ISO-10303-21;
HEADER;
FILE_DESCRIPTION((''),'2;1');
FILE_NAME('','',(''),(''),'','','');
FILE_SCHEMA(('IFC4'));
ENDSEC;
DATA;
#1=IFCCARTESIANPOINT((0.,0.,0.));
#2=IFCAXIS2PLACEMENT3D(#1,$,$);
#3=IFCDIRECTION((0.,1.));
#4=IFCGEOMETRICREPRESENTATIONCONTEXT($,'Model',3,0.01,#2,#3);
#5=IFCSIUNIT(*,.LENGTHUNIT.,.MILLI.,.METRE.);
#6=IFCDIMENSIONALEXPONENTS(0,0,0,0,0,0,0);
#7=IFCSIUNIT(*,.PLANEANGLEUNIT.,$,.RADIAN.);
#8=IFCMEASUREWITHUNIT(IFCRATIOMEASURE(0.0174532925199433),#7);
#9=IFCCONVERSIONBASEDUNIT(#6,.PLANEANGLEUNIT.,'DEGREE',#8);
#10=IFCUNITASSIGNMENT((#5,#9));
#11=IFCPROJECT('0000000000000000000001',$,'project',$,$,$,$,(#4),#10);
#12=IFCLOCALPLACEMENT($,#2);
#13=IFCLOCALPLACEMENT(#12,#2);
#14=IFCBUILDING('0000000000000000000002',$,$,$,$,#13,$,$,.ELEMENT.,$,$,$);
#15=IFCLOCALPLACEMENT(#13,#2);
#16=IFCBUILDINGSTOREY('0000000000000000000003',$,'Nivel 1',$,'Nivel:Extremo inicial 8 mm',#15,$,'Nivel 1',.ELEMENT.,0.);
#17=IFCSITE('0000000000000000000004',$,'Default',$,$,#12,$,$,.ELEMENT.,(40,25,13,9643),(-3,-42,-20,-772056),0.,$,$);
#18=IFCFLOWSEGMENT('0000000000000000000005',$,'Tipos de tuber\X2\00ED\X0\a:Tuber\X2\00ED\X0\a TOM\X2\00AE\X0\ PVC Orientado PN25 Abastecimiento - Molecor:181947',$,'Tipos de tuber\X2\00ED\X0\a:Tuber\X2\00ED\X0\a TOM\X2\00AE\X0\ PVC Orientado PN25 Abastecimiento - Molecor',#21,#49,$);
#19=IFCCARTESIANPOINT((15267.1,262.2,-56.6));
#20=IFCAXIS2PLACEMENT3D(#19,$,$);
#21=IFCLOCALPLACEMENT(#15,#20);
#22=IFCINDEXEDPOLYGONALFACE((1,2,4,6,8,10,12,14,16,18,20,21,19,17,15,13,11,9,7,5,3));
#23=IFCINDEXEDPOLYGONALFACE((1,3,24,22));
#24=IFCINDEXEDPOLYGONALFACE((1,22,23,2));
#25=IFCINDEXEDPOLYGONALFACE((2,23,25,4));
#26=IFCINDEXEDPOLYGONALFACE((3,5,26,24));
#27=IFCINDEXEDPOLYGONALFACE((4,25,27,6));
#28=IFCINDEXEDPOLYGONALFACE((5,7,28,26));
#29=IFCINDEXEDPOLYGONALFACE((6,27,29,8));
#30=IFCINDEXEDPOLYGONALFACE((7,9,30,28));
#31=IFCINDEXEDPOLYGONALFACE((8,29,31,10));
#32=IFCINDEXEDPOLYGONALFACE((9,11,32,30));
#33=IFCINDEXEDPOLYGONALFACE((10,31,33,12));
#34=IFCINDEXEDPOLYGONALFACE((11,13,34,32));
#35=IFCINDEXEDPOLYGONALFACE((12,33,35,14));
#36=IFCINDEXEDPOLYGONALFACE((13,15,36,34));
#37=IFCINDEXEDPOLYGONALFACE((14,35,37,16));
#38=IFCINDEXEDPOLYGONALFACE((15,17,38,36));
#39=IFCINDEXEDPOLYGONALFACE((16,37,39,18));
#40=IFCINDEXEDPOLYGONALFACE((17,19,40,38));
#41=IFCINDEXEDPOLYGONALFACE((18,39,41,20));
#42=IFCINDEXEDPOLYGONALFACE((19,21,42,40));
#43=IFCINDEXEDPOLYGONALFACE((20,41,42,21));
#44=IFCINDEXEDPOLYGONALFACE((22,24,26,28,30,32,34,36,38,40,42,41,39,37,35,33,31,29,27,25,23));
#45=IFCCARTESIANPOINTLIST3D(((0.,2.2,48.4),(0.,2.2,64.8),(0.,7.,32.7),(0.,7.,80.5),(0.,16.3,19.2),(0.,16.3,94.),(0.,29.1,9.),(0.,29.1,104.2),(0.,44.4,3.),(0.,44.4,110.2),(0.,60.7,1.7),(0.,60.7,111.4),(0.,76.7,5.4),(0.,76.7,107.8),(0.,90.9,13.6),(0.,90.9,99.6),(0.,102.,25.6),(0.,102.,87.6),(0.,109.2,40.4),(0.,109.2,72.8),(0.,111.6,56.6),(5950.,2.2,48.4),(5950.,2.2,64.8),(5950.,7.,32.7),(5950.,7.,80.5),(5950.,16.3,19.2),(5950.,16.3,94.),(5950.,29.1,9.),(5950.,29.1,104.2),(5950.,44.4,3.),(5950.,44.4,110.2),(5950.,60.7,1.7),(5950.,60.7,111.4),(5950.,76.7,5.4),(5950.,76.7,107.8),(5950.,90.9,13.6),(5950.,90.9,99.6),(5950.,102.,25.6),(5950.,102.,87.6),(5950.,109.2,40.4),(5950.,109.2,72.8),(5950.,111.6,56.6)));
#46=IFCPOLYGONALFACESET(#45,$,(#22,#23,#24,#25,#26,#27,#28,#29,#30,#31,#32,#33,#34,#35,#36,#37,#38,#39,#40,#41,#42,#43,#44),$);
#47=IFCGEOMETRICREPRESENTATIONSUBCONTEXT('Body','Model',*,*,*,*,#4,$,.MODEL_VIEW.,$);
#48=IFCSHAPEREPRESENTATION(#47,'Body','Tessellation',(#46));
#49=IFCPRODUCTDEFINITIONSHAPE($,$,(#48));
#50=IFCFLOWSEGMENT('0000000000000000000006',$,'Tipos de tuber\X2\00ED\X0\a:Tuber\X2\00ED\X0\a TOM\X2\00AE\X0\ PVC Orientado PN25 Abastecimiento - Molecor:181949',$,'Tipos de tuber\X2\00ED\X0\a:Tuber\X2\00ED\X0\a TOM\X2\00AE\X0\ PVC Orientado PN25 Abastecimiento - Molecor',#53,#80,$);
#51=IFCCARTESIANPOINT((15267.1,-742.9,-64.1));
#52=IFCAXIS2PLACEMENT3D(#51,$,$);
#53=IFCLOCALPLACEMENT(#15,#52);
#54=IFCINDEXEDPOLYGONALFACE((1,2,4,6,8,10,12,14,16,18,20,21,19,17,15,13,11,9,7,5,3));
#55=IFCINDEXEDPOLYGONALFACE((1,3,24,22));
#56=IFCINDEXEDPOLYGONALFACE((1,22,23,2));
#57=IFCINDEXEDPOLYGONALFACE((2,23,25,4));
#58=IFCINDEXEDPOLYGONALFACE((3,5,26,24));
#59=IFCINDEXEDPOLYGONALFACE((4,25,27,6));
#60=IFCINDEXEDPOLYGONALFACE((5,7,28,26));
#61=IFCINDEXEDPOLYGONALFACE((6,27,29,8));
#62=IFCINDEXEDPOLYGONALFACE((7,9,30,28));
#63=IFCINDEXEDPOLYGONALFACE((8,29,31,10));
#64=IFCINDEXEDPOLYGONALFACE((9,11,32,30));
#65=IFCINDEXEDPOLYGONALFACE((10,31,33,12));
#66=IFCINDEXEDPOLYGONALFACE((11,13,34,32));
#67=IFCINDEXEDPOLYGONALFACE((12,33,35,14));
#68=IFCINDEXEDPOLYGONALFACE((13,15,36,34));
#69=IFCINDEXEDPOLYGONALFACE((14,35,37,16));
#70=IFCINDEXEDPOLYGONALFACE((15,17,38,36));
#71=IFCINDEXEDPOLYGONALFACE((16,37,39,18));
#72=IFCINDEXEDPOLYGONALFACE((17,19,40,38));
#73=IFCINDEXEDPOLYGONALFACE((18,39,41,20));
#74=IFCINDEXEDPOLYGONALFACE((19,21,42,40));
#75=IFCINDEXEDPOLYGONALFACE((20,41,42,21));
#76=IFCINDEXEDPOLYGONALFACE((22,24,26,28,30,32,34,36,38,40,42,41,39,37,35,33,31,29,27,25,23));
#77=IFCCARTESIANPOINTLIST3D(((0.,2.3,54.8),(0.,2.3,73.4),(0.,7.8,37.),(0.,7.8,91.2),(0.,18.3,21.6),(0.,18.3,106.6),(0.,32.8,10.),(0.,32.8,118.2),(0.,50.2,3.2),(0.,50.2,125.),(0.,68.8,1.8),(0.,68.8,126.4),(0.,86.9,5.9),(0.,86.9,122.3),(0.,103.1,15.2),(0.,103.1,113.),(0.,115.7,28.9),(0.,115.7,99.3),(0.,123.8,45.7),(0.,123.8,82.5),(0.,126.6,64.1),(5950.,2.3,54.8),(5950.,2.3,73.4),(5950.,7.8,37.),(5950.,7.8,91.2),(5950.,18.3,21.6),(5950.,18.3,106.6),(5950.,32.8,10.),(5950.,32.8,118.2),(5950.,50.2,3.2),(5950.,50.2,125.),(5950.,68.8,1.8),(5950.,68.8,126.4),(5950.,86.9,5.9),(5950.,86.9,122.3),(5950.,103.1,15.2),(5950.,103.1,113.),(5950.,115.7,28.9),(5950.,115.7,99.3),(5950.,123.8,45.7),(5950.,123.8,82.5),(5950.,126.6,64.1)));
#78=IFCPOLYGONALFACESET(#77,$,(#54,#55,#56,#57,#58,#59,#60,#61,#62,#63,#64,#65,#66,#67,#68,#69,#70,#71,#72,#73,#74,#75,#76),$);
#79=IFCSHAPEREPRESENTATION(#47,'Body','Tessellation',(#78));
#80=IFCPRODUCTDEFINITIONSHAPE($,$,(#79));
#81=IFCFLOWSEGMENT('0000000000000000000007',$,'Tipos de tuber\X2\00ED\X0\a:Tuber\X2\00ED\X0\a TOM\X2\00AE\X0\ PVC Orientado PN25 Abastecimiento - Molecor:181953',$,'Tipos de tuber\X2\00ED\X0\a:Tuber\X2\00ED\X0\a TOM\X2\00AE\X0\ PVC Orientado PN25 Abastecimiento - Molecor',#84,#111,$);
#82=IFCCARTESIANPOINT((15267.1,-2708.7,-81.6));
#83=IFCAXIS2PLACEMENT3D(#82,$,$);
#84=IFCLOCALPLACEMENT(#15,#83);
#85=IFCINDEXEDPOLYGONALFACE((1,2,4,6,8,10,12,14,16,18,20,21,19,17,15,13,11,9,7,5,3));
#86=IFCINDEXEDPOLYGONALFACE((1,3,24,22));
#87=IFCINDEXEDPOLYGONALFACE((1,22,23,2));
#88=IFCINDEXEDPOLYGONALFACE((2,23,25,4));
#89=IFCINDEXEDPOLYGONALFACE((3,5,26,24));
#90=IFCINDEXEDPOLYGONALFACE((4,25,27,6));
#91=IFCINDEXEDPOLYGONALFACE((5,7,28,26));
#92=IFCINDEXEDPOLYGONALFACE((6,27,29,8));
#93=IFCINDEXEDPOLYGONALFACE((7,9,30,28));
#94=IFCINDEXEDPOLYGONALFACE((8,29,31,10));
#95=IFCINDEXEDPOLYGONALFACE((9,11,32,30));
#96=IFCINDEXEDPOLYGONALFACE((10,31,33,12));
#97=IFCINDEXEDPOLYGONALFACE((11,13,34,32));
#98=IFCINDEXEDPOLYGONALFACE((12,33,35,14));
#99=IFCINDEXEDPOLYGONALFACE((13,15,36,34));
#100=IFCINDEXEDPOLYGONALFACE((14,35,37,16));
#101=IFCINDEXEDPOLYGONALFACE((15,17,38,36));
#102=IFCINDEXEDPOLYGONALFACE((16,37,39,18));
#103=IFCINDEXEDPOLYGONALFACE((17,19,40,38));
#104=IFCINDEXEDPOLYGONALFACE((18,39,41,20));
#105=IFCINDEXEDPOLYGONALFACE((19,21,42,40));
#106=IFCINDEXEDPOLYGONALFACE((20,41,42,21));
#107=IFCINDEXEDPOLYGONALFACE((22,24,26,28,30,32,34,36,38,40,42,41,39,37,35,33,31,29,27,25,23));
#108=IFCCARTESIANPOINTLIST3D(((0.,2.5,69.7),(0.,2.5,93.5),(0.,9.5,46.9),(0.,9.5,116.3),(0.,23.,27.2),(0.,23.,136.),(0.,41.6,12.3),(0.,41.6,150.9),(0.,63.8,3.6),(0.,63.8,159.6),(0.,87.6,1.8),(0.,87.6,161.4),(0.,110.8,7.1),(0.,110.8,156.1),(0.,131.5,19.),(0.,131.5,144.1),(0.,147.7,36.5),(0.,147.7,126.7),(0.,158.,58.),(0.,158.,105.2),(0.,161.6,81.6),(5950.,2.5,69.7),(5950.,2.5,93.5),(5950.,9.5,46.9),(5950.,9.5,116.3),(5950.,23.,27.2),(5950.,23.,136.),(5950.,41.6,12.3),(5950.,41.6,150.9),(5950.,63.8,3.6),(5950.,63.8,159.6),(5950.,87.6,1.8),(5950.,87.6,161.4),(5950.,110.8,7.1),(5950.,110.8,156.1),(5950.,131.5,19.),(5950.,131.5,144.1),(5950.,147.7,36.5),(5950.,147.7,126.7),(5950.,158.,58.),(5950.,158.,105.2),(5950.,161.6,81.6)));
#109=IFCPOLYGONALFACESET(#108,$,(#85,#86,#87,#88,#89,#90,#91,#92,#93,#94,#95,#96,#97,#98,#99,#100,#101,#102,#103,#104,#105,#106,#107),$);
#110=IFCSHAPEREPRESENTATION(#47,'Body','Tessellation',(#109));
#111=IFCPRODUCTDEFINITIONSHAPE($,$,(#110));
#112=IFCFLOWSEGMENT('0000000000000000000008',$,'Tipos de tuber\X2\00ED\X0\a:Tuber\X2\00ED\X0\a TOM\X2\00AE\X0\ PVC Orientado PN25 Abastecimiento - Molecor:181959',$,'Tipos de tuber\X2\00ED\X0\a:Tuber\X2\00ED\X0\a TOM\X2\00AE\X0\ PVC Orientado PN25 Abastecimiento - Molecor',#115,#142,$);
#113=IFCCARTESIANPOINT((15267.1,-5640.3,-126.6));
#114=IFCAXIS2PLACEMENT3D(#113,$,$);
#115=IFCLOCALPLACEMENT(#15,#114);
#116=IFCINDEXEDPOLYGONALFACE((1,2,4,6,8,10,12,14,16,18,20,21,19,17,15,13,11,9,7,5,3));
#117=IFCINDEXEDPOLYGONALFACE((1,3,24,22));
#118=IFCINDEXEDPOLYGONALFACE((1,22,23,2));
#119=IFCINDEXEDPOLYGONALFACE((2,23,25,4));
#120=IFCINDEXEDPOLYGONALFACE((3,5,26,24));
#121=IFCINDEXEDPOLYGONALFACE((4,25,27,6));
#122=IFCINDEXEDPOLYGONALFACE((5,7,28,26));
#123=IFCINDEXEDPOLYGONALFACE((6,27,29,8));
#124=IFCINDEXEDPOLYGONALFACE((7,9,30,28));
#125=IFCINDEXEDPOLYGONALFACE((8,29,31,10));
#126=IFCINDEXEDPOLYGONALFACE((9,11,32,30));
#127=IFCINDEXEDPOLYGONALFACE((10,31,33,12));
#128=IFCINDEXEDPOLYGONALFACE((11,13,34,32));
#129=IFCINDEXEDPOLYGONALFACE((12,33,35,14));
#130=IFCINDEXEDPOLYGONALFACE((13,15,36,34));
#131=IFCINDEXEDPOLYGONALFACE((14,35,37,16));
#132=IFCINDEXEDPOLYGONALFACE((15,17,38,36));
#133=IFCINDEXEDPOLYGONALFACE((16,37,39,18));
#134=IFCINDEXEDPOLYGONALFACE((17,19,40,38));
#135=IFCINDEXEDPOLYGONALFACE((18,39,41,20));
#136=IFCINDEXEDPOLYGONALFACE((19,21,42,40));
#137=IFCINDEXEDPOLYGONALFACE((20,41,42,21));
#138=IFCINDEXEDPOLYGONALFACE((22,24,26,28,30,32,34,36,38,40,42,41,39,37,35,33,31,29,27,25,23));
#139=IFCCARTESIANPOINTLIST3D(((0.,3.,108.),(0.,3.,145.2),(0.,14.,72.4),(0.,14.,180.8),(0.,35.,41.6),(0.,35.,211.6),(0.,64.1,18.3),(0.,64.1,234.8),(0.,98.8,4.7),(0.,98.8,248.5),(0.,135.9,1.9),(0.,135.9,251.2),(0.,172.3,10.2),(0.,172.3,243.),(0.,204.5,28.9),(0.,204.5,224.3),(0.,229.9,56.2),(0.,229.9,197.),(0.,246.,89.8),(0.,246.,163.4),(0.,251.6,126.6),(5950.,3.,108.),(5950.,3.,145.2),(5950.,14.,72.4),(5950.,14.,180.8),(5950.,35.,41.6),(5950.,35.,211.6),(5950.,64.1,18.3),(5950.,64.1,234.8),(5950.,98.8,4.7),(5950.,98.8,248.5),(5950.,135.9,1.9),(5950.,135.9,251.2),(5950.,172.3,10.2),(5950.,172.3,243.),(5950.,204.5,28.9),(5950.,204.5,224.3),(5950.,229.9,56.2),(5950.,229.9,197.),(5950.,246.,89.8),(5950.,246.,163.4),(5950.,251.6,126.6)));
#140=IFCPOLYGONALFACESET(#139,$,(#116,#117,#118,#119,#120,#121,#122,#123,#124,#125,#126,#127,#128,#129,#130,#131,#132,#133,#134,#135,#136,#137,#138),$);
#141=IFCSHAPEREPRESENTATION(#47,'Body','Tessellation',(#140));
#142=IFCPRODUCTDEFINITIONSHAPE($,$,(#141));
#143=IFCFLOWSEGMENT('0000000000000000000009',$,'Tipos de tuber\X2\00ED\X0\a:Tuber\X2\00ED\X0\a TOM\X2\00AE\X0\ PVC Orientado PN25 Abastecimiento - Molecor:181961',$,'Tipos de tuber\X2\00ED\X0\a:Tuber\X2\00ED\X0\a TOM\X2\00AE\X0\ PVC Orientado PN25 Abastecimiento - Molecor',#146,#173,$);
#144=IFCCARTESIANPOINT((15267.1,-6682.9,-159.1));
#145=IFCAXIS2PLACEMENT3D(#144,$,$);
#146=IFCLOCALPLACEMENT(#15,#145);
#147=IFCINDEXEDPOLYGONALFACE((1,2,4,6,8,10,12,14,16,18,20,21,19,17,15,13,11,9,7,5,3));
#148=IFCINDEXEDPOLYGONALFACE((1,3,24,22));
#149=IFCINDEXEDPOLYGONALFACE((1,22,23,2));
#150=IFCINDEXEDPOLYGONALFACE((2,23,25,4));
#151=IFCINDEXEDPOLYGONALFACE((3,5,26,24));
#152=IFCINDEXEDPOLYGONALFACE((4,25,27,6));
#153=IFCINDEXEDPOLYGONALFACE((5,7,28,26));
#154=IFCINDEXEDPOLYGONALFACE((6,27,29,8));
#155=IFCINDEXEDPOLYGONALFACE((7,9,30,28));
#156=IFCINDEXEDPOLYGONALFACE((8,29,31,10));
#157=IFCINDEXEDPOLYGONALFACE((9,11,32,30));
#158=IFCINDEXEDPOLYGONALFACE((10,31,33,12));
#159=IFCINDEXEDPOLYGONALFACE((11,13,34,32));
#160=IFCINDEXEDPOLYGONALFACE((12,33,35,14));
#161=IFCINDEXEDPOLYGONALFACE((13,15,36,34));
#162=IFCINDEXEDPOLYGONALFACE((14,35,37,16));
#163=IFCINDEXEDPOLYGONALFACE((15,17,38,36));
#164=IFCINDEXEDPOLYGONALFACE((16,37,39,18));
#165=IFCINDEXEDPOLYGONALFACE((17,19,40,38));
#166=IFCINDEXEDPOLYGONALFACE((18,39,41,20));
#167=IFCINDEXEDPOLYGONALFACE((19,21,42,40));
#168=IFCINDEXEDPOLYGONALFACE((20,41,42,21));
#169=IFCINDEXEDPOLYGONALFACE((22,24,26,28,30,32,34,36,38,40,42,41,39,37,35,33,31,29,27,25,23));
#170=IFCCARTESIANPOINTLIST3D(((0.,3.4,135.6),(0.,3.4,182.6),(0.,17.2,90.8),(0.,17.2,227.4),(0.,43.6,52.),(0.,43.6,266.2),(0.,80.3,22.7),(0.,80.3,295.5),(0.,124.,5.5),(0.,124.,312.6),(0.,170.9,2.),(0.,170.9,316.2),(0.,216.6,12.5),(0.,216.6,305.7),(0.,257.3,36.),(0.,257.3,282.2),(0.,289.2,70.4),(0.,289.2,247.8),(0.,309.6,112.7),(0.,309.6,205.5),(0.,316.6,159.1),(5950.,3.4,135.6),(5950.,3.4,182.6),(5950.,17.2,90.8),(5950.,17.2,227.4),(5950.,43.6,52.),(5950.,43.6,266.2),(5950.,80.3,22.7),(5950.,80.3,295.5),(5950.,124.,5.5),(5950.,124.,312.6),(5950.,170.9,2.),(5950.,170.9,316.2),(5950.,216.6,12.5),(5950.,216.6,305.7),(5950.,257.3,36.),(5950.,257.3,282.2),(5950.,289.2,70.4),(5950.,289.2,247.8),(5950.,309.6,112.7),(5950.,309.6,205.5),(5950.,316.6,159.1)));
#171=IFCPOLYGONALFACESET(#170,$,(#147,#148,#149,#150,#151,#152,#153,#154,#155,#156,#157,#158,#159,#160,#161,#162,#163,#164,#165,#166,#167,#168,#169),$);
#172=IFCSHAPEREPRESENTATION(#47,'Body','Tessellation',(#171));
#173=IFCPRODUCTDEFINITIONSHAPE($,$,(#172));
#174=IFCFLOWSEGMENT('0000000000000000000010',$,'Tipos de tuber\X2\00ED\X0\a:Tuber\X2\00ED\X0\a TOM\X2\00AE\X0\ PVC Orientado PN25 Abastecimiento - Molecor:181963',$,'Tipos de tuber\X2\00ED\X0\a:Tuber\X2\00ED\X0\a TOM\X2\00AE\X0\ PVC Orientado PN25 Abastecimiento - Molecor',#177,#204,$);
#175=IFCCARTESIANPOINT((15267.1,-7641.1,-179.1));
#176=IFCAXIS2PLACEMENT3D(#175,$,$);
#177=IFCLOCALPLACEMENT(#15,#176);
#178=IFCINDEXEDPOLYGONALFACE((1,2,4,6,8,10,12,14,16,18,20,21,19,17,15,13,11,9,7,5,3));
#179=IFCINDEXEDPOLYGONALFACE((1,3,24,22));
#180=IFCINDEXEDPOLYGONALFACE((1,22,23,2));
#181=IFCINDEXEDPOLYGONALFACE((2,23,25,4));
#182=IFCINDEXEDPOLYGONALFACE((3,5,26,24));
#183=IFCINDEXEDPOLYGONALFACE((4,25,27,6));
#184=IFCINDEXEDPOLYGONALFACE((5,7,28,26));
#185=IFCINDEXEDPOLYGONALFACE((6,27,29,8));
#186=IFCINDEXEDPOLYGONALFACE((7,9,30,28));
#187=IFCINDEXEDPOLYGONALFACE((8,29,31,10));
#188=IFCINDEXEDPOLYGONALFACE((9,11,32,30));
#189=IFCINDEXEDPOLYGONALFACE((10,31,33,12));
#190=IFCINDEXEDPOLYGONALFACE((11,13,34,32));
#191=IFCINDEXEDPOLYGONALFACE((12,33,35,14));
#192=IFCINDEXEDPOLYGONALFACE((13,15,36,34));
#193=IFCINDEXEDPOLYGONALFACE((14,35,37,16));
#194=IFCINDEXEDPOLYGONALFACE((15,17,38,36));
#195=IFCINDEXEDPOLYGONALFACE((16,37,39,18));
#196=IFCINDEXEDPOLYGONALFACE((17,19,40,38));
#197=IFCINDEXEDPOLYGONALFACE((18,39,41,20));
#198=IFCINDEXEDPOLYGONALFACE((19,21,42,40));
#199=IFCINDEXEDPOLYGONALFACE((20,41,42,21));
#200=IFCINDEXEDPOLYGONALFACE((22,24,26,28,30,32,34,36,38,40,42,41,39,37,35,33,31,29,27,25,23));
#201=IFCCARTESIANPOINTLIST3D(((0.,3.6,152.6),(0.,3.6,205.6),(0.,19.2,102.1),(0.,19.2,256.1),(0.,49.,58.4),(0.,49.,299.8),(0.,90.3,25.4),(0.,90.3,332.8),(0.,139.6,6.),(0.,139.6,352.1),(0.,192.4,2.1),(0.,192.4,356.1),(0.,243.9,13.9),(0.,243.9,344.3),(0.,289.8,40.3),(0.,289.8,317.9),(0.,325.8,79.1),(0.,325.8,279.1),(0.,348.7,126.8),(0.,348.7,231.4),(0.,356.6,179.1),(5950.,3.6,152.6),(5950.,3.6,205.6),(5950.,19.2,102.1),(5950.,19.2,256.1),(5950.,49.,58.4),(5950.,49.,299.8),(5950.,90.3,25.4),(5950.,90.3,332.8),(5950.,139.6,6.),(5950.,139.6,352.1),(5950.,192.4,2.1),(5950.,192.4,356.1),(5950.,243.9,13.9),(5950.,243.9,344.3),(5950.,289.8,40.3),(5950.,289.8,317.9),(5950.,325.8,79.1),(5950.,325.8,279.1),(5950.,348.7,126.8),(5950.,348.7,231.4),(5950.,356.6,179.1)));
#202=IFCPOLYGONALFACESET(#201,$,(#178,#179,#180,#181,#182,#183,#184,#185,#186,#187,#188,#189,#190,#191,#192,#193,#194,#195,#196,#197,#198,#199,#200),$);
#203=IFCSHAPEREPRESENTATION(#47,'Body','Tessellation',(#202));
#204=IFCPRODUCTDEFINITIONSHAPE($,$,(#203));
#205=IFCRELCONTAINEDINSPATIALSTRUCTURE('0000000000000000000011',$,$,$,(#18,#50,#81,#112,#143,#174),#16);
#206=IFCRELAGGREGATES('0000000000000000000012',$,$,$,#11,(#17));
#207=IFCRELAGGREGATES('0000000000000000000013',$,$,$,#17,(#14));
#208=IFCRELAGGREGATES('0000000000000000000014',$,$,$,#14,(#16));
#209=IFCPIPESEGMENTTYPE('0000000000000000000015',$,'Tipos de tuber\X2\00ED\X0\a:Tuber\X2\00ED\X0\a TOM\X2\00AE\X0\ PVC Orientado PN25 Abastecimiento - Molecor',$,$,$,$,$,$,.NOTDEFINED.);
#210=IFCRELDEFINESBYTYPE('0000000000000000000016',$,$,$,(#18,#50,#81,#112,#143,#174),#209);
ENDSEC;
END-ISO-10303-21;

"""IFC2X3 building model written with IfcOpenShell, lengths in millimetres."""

from ifc_helpers import new_model, entity, si_unit, converted_unit, direction, frame, frame_2d, origin, place, context, subcontext, project, spatial, circle, extrude, type_object, element, save


model = new_model("IFC2X3")

# Units and contexts
model_context = context("Model", 3, precision=0.01, world=origin(), true_north=direction((0.0, 1.0)))
body_context = subcontext(model_context, "Body", "Model", "MODEL_VIEW")
ifc_project = project(units=[si_unit("LENGTHUNIT", "METRE", prefix="MILLI"), converted_unit("PLANEANGLEUNIT", "DEGREE", entity("IfcRatioMeasure", 0.0174532925199433), si_unit("PLANEANGLEUNIT", "RADIAN"), dimensions=[0, 0, 0, 0, 0, 0, 0])], contexts=[model_context])

# Site, building, storey
site_placement = place(None, origin())
site = spatial("IfcSite", under=ifc_project, at=site_placement, Name="Default", CompositionType="ELEMENT", RefLatitude=(40, 25, 13, 9643), RefLongitude=(-3, -42, -20, -772056), RefElevation=0.0)
building_placement = place(site_placement, origin())
building = spatial("IfcBuilding", under=site, at=building_placement, CompositionType="ELEMENT")
storey_placement = place(building_placement, origin())
storey = spatial("IfcBuildingStorey", under=building, at=storey_placement, Name="Nivel 1", ObjectType="Nivel:Extremo inicial 8 mm", LongName="Nivel 1", CompositionType="ELEMENT", Elevation=0.0)

# Flow segments
pipe_segment_type = type_object("IfcPipeSegmentType", Name="Tipos de tubería:Tubería TOM® PVC Orientado PN25 Abastecimiento - Molecor", PredefinedType="NOTDEFINED")
flow_segment_1_placement = place(storey_placement, frame((15267.1, 262.2, -56.6)))
element("IfcFlowSegment", 1, at=flow_segment_1_placement, inside=storey, type_object=pipe_segment_type, Name="Tipos de tubería:Tubería TOM® PVC Orientado PN25 Abastecimiento - Molecor:181947", ObjectType="Tipos de tubería:Tubería TOM® PVC Orientado PN25 Abastecimiento - Molecor", context=body_context, shape_type="SweptSolid", body=[
    extrude(circle(Radius=55.0, at=frame_2d((0.0, 0.0), x_axis=(1.0, 0.0))), frame((0.0, 56.6, 56.6), z_axis=(1.0, 0.0, 0.0), x_axis=(0.0, 1.0, 0.0)), (0.0, 0.0, 1.0), 5950.0),
])
flow_segment_2_placement = place(storey_placement, frame((15267.1, -742.9, -64.1)))
element("IfcFlowSegment", 2, at=flow_segment_2_placement, inside=storey, type_object=pipe_segment_type, Name="Tipos de tubería:Tubería TOM® PVC Orientado PN25 Abastecimiento - Molecor:181949", ObjectType="Tipos de tubería:Tubería TOM® PVC Orientado PN25 Abastecimiento - Molecor", context=body_context, shape_type="SweptSolid", body=[
    extrude(circle(Radius=62.5, at=frame_2d((0.0, 0.0), x_axis=(1.0, 0.0))), frame((0.0, 64.1, 64.1), z_axis=(1.0, 0.0, 0.0), x_axis=(0.0, 1.0, 0.0)), (0.0, 0.0, 1.0), 5950.0),
])
flow_segment_3_placement = place(storey_placement, frame((15267.1, -2708.7, -81.6)))
element("IfcFlowSegment", 3, at=flow_segment_3_placement, inside=storey, type_object=pipe_segment_type, Name="Tipos de tubería:Tubería TOM® PVC Orientado PN25 Abastecimiento - Molecor:181953", ObjectType="Tipos de tubería:Tubería TOM® PVC Orientado PN25 Abastecimiento - Molecor", context=body_context, shape_type="SweptSolid", body=[
    extrude(circle(Radius=80.0, at=frame_2d((0.0, 0.0), x_axis=(1.0, 0.0))), frame((0.0, 81.6, 81.6), z_axis=(1.0, 0.0, 0.0), x_axis=(0.0, 1.0, 0.0)), (0.0, 0.0, 1.0), 5950.0),
])
flow_segment_4_placement = place(storey_placement, frame((15267.1, -5640.3, -126.6)))
element("IfcFlowSegment", 4, at=flow_segment_4_placement, inside=storey, type_object=pipe_segment_type, Name="Tipos de tubería:Tubería TOM® PVC Orientado PN25 Abastecimiento - Molecor:181959", ObjectType="Tipos de tubería:Tubería TOM® PVC Orientado PN25 Abastecimiento - Molecor", context=body_context, shape_type="SweptSolid", body=[
    extrude(circle(Radius=125.0, at=frame_2d((0.0, 0.0), x_axis=(1.0, 0.0))), frame((0.0, 126.6, 126.6), z_axis=(1.0, 0.0, 0.0), x_axis=(0.0, 1.0, 0.0)), (0.0, 0.0, 1.0), 5950.0),
])
flow_segment_5_placement = place(storey_placement, frame((15267.1, -6682.9, -159.1)))
element("IfcFlowSegment", 5, at=flow_segment_5_placement, inside=storey, type_object=pipe_segment_type, Name="Tipos de tubería:Tubería TOM® PVC Orientado PN25 Abastecimiento - Molecor:181961", ObjectType="Tipos de tubería:Tubería TOM® PVC Orientado PN25 Abastecimiento - Molecor", context=body_context, shape_type="SweptSolid", body=[
    extrude(circle(Radius=157.5, at=frame_2d((0.0, 0.0), x_axis=(1.0, 0.0))), frame((0.0, 159.1, 159.1), z_axis=(1.0, 0.0, 0.0), x_axis=(0.0, 1.0, 0.0)), (0.0, 0.0, 1.0), 5950.0),
])
flow_segment_6_placement = place(storey_placement, frame((15267.1, -7641.1, -179.1)))
element("IfcFlowSegment", 6, at=flow_segment_6_placement, inside=storey, type_object=pipe_segment_type, Name="Tipos de tubería:Tubería TOM® PVC Orientado PN25 Abastecimiento - Molecor:181963", ObjectType="Tipos de tubería:Tubería TOM® PVC Orientado PN25 Abastecimiento - Molecor", context=body_context, shape_type="SweptSolid", body=[
    extrude(circle(Radius=177.5, at=frame_2d((0.0, 0.0), x_axis=(1.0, 0.0))), frame((0.0, 179.1, 179.1), z_axis=(1.0, 0.0, 0.0), x_axis=(0.0, 1.0, 0.0)), (0.0, 0.0, 1.0), 5950.0),
])

save(model, "model.ifc")
